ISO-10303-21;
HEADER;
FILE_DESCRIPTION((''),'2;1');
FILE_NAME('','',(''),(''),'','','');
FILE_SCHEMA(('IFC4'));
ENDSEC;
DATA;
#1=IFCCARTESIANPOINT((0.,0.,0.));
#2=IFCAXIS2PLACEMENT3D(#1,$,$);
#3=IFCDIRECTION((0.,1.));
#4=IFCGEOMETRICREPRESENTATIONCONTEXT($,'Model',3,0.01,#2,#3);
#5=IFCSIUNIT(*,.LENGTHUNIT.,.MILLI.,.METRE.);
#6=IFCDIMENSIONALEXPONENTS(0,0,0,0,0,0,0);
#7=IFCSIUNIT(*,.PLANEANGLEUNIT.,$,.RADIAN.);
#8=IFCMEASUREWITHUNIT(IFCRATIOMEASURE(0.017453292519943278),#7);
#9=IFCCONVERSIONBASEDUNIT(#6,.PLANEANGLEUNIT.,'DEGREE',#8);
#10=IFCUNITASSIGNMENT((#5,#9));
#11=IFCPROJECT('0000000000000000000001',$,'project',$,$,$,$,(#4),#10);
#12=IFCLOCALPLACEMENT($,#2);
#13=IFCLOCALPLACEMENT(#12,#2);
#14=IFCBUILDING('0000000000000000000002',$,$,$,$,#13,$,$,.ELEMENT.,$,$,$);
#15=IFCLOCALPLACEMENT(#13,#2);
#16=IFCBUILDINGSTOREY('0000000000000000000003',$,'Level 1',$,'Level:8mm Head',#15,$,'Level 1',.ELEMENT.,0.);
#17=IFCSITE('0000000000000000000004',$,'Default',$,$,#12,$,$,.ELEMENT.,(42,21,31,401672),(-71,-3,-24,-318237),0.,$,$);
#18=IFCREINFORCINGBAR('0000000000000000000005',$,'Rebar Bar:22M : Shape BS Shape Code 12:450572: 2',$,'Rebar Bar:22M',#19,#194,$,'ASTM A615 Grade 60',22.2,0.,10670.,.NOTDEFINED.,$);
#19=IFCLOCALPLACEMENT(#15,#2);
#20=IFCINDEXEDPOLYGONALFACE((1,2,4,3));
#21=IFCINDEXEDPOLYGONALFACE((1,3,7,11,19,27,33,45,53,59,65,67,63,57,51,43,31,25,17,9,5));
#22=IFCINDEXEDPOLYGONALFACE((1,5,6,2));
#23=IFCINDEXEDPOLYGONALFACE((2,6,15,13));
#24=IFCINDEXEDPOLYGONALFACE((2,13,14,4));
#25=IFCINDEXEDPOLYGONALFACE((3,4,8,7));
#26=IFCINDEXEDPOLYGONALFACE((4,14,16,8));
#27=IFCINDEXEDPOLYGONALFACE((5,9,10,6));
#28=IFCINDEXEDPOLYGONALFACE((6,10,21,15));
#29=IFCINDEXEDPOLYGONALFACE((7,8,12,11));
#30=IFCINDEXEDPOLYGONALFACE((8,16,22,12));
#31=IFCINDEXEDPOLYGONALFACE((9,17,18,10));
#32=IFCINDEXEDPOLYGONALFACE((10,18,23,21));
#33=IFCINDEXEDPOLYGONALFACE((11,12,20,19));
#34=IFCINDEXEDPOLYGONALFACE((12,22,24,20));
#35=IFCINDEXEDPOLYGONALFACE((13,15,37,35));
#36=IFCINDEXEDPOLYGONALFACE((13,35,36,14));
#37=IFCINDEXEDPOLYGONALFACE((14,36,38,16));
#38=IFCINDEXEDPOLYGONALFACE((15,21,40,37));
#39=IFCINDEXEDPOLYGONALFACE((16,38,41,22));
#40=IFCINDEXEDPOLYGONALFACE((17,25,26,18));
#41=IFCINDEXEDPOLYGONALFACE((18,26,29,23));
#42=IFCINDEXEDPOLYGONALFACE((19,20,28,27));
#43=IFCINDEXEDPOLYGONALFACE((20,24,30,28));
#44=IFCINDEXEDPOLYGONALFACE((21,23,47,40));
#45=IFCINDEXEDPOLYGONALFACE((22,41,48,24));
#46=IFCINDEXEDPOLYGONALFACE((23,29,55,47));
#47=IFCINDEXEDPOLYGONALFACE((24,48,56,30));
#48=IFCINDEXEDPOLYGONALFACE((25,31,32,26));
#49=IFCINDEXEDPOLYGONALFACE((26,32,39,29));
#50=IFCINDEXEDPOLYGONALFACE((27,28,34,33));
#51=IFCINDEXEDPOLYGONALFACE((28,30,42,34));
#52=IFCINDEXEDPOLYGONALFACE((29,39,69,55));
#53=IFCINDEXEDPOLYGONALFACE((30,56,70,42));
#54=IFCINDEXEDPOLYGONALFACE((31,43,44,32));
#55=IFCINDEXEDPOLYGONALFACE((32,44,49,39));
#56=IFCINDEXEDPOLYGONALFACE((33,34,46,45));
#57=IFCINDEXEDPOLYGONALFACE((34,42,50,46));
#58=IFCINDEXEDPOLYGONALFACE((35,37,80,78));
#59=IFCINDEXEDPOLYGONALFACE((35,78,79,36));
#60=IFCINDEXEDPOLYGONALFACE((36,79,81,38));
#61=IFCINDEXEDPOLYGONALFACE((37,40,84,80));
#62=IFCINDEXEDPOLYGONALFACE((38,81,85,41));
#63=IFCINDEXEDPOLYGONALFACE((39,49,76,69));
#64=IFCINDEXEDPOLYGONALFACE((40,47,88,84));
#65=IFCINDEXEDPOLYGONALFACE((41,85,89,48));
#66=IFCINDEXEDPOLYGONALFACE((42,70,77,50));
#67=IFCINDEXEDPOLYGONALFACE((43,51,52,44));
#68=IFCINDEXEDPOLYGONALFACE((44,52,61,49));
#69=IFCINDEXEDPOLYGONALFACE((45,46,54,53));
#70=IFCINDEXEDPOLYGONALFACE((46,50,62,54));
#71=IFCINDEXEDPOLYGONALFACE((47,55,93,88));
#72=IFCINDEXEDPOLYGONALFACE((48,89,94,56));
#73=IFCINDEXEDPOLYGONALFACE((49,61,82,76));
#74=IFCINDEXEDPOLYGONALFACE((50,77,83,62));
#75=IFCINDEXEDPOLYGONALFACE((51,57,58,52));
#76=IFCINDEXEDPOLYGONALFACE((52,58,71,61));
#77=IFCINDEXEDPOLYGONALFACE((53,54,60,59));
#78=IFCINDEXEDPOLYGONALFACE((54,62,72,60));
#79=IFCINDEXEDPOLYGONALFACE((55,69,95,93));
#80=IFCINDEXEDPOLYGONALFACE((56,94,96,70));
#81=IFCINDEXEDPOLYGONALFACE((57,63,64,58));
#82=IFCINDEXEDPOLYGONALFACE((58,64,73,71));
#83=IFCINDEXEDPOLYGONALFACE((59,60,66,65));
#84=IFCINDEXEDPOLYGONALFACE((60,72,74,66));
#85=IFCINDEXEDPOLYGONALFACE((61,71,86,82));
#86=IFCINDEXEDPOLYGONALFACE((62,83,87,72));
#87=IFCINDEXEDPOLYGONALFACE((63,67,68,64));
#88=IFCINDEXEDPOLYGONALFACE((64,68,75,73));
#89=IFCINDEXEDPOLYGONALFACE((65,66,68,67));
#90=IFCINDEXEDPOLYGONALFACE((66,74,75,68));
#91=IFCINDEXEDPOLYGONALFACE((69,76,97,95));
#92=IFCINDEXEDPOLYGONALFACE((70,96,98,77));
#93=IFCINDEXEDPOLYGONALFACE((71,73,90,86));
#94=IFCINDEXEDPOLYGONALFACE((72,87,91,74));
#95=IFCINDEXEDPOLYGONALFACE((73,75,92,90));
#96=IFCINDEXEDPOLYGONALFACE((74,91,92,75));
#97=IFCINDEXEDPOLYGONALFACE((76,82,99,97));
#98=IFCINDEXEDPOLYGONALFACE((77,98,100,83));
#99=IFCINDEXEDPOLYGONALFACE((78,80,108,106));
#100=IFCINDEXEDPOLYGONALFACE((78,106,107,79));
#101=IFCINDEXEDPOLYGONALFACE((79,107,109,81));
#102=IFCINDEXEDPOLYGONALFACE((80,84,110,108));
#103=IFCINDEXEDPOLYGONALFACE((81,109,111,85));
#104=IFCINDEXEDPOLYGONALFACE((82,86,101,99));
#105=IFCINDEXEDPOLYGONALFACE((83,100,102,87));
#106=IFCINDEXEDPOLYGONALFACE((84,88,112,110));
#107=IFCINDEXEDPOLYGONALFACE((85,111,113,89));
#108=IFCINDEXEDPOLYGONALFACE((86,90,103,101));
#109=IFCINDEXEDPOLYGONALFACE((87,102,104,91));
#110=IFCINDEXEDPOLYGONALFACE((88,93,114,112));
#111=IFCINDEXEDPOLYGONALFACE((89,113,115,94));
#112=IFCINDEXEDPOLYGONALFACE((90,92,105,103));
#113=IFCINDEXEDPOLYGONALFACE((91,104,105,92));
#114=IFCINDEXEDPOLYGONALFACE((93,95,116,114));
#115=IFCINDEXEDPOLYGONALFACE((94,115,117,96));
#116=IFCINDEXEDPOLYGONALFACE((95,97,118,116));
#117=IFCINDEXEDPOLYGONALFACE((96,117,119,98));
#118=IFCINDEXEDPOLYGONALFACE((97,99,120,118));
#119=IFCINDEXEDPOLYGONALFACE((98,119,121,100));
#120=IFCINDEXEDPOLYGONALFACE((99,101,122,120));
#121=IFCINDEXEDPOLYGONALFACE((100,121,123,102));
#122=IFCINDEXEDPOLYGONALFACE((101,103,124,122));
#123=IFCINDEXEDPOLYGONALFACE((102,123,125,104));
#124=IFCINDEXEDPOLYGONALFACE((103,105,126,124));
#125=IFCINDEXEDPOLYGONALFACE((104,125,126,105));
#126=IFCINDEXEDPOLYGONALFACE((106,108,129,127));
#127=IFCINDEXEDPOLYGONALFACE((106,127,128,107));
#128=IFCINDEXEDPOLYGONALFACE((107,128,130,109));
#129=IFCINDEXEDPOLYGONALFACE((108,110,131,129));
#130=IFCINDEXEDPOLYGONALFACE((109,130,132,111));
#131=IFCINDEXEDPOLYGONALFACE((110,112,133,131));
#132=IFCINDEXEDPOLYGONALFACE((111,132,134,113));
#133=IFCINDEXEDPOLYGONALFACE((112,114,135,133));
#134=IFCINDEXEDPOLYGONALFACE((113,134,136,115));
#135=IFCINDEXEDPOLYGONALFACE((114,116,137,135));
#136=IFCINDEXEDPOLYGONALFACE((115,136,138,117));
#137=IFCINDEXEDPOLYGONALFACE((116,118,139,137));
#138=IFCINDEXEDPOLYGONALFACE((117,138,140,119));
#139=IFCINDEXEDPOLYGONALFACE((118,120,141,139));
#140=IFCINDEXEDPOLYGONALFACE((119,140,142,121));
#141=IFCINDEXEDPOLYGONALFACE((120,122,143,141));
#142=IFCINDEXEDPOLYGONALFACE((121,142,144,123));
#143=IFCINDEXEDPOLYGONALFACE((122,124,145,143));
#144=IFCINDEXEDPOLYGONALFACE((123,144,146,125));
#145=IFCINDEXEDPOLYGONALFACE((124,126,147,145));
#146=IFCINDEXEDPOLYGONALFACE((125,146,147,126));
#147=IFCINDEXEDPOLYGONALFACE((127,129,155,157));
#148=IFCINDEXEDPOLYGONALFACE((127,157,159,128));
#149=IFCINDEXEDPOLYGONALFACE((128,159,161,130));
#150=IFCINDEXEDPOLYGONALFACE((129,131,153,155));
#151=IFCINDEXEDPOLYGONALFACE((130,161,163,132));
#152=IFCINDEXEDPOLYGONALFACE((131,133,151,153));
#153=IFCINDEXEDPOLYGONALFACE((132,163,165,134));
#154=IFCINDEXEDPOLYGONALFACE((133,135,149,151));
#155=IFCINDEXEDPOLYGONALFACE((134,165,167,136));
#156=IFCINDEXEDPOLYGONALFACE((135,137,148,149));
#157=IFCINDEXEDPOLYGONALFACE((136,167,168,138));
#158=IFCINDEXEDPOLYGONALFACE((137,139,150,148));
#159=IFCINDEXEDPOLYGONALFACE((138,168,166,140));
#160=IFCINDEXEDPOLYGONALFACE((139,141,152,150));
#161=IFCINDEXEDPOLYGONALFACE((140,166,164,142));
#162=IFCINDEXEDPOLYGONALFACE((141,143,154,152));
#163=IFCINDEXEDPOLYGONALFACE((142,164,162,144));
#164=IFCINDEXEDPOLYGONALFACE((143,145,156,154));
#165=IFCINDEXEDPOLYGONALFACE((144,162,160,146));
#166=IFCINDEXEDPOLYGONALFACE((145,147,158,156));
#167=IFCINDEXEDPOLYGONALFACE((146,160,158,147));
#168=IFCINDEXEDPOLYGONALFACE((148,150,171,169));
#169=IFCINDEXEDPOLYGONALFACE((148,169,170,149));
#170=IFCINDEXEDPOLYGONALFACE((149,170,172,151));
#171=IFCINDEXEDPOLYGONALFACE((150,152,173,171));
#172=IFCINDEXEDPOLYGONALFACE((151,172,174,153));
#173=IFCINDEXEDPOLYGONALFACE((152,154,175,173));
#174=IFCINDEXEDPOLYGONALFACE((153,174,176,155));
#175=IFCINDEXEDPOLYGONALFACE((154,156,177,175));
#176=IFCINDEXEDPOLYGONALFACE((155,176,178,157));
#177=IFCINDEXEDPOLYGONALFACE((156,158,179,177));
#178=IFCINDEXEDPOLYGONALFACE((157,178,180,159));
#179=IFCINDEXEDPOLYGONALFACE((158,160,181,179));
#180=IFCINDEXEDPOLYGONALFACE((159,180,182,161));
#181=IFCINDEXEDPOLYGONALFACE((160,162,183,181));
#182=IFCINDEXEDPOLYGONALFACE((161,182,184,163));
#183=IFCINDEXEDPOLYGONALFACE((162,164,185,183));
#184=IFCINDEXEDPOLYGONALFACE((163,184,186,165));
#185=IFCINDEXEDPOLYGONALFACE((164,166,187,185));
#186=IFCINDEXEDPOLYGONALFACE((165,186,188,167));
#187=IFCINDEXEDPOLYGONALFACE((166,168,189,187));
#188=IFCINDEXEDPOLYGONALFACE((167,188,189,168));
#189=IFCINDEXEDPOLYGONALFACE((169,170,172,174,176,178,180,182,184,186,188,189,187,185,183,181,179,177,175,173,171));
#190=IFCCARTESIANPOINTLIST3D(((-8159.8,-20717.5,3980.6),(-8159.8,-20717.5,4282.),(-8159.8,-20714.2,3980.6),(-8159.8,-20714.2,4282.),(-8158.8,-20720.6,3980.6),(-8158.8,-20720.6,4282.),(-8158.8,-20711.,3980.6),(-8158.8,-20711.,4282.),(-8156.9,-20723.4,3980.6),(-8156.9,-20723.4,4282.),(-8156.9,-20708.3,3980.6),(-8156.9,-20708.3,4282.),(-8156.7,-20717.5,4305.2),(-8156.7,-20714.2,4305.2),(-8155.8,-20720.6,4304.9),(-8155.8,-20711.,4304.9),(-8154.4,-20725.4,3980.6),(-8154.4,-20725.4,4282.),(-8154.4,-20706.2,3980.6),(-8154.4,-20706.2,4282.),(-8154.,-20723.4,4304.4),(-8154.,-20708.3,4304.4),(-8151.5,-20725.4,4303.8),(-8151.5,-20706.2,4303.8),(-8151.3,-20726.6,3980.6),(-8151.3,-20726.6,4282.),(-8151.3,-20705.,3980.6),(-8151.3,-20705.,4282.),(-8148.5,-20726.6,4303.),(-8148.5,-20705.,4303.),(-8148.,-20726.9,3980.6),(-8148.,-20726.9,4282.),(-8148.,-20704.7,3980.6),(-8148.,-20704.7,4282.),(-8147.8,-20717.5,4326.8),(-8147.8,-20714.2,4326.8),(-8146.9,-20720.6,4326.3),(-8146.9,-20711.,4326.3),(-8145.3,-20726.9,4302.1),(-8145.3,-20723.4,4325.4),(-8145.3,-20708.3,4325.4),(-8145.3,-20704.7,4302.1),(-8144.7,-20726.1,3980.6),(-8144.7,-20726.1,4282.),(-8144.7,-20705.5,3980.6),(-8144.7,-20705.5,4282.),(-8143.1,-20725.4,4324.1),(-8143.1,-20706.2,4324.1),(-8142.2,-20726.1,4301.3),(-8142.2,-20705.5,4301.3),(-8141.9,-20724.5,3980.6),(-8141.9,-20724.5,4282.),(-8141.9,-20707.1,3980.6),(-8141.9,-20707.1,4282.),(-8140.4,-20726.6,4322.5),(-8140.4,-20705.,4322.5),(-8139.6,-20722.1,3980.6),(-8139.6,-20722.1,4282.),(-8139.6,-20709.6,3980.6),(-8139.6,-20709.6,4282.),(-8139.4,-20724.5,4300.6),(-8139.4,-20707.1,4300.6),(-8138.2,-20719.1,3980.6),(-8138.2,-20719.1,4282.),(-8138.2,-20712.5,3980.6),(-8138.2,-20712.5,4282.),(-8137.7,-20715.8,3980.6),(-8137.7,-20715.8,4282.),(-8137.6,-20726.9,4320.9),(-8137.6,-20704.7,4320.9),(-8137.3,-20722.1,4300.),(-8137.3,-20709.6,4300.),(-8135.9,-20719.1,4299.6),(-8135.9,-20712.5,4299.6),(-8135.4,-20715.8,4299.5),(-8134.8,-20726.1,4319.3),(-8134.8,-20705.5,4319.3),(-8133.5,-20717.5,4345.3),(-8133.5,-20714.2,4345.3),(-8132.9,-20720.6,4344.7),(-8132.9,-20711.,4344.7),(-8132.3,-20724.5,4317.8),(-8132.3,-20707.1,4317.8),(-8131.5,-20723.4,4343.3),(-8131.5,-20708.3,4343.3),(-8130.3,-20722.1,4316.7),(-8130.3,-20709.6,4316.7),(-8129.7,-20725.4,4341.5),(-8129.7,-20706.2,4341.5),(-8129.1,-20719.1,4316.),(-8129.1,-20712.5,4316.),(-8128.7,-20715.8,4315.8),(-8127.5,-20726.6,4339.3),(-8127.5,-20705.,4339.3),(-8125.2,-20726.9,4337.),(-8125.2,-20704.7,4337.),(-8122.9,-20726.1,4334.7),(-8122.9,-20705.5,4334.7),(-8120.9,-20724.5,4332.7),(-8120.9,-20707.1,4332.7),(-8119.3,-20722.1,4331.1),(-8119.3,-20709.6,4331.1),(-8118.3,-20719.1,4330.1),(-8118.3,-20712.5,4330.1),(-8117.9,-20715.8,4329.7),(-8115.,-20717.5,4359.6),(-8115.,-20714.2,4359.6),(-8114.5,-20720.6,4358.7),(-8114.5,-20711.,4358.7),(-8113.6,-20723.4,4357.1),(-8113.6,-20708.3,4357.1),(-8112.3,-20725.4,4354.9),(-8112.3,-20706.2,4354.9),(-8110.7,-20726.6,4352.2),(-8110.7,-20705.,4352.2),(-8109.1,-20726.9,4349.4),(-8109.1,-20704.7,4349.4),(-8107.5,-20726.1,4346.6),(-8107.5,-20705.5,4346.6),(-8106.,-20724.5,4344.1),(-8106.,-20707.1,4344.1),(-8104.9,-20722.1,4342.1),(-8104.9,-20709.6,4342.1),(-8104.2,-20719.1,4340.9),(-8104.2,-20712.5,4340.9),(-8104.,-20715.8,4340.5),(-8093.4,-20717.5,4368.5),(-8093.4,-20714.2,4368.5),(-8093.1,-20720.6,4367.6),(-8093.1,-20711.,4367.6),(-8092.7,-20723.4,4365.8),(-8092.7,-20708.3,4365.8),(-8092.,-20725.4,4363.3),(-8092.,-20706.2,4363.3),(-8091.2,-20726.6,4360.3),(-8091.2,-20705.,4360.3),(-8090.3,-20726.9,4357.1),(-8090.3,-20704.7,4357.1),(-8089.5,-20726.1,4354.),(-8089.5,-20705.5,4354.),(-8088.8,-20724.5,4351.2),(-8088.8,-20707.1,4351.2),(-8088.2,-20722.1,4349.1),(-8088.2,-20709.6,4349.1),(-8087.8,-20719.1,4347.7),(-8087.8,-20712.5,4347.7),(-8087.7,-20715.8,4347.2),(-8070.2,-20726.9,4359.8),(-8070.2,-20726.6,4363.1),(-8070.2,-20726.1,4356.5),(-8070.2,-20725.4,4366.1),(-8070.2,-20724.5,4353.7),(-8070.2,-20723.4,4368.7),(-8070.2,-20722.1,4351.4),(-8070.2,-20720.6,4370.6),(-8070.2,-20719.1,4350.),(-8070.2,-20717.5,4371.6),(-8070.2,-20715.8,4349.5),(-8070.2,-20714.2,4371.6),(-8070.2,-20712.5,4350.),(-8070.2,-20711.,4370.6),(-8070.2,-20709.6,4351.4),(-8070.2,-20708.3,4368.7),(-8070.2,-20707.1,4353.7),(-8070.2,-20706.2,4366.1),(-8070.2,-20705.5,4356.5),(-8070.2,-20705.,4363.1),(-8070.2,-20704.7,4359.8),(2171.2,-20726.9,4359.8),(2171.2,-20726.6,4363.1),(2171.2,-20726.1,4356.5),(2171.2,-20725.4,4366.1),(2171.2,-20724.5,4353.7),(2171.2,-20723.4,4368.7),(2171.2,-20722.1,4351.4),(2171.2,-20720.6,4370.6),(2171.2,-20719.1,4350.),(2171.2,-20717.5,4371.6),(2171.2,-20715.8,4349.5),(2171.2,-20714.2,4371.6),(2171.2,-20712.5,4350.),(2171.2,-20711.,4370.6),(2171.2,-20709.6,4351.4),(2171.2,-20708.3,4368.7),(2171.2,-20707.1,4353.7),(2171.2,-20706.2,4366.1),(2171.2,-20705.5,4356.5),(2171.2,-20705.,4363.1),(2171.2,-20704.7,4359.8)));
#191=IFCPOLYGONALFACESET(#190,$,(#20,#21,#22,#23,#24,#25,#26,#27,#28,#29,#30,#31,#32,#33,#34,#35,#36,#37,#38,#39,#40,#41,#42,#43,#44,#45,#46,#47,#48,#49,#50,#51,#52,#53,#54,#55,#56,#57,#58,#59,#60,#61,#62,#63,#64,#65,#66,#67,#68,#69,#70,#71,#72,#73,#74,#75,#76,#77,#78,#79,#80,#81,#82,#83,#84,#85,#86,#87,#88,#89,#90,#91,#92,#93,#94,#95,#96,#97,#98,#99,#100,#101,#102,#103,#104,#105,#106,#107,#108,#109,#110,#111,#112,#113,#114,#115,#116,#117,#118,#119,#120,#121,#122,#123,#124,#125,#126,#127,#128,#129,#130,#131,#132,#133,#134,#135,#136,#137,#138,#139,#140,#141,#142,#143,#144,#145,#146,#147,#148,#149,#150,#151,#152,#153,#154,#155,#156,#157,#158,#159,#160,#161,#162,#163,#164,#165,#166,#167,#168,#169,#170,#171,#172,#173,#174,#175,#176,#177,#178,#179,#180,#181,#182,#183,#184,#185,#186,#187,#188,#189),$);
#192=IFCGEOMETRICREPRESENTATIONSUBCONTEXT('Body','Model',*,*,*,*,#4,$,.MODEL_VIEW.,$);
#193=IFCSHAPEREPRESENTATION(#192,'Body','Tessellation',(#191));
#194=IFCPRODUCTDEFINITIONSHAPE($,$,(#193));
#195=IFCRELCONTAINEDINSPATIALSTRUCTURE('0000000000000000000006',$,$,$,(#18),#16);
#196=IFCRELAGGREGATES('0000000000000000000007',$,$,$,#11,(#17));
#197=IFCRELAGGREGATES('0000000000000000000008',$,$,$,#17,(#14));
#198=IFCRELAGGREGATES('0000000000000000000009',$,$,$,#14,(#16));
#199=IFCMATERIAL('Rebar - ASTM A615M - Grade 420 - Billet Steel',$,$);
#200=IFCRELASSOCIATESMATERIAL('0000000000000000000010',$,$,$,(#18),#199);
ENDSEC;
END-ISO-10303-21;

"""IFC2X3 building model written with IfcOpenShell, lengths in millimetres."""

from ifc_helpers import new_model, entity, si_unit, converted_unit, direction, origin, place, context, subcontext, project, spatial, material, element, save


model = new_model("IFC2X3")

# Units and contexts
model_context = context("Model", 3, precision=0.01, world=origin(), true_north=direction((0.0, 1.0)))
body_context = subcontext(model_context, "Body", "Model", "MODEL_VIEW")
ifc_project = project(units=[si_unit("LENGTHUNIT", "METRE", prefix="MILLI"), converted_unit("PLANEANGLEUNIT", "DEGREE", entity("IfcRatioMeasure", 0.017453292519943278), si_unit("PLANEANGLEUNIT", "RADIAN"), dimensions=[0, 0, 0, 0, 0, 0, 0])], contexts=[model_context])

# Site, building, storey
site_placement = place(None, origin())
site = spatial("IfcSite", under=ifc_project, at=site_placement, Name="Default", CompositionType="ELEMENT", RefLatitude=(42, 21, 31, 401672), RefLongitude=(-71, -3, -24, -318237), RefElevation=0.0)
building_placement = place(site_placement, origin())
building = spatial("IfcBuilding", under=site, at=building_placement, CompositionType="ELEMENT")
storey_placement = place(building_placement, origin())
storey = spatial("IfcBuildingStorey", under=building, at=storey_placement, Name="Level 1", ObjectType="Level:8mm Head", LongName="Level 1", CompositionType="ELEMENT", Elevation=0.0)

# Reinforcing bar
ifc_material = material(Name="Rebar - ASTM A615M - Grade 420 - Billet Steel")
reinforcing_bar_1_placement = place(storey_placement, origin())
element("IfcReinforcingBar", 1, at=reinforcing_bar_1_placement, inside=storey, material=ifc_material, Name="Rebar Bar:22M : Shape BS Shape Code 12:450572: 2", SteelGrade="ASTM A615 Grade 60", ObjectType="Rebar Bar:22M", BarLength=10670.0, BarRole="NOTDEFINED", CrossSectionArea=0.0, NominalDiameter=22.2, context=body_context, shape_type="AdvancedSweptSolid", body=[
    entity("IfcSweptDiskSolid", entity("IfcCompositeCurve", [entity("IfcCompositeCurveSegment", "CONTINUOUS", True, entity("IfcPolyline", [entity("IfcCartesianPoint", [2171.2, -20715.8, 4360.6]), entity("IfcCartesianPoint", [-8070.2, -20715.8, 4360.6])])), entity("IfcCompositeCurveSegment", "CONTINUOUS", True, entity("IfcTrimmedCurve", entity("IfcCircle", entity("IfcAxis2Placement3D", entity("IfcCartesianPoint", [-8070.2, -20715.8, 4282.0]), entity("IfcDirection", [0.0, -1.0, 0.0]), entity("IfcDirection", [-1.0, 0.0, 0.0])), 78.6), [entity("IfcParameterValue", 270.0)], [entity("IfcParameterValue", 360.0)], True, "PARAMETER")), entity("IfcCompositeCurveSegment", "CONTINUOUS", True, entity("IfcPolyline", [entity("IfcCartesianPoint", [-8148.8, -20715.8, 4282.0]), entity("IfcCartesianPoint", [-8148.8, -20715.8, 3980.6])]))], False), 11.1, None, 0.0, 92.0),
])

save(model, "model.ifc")
